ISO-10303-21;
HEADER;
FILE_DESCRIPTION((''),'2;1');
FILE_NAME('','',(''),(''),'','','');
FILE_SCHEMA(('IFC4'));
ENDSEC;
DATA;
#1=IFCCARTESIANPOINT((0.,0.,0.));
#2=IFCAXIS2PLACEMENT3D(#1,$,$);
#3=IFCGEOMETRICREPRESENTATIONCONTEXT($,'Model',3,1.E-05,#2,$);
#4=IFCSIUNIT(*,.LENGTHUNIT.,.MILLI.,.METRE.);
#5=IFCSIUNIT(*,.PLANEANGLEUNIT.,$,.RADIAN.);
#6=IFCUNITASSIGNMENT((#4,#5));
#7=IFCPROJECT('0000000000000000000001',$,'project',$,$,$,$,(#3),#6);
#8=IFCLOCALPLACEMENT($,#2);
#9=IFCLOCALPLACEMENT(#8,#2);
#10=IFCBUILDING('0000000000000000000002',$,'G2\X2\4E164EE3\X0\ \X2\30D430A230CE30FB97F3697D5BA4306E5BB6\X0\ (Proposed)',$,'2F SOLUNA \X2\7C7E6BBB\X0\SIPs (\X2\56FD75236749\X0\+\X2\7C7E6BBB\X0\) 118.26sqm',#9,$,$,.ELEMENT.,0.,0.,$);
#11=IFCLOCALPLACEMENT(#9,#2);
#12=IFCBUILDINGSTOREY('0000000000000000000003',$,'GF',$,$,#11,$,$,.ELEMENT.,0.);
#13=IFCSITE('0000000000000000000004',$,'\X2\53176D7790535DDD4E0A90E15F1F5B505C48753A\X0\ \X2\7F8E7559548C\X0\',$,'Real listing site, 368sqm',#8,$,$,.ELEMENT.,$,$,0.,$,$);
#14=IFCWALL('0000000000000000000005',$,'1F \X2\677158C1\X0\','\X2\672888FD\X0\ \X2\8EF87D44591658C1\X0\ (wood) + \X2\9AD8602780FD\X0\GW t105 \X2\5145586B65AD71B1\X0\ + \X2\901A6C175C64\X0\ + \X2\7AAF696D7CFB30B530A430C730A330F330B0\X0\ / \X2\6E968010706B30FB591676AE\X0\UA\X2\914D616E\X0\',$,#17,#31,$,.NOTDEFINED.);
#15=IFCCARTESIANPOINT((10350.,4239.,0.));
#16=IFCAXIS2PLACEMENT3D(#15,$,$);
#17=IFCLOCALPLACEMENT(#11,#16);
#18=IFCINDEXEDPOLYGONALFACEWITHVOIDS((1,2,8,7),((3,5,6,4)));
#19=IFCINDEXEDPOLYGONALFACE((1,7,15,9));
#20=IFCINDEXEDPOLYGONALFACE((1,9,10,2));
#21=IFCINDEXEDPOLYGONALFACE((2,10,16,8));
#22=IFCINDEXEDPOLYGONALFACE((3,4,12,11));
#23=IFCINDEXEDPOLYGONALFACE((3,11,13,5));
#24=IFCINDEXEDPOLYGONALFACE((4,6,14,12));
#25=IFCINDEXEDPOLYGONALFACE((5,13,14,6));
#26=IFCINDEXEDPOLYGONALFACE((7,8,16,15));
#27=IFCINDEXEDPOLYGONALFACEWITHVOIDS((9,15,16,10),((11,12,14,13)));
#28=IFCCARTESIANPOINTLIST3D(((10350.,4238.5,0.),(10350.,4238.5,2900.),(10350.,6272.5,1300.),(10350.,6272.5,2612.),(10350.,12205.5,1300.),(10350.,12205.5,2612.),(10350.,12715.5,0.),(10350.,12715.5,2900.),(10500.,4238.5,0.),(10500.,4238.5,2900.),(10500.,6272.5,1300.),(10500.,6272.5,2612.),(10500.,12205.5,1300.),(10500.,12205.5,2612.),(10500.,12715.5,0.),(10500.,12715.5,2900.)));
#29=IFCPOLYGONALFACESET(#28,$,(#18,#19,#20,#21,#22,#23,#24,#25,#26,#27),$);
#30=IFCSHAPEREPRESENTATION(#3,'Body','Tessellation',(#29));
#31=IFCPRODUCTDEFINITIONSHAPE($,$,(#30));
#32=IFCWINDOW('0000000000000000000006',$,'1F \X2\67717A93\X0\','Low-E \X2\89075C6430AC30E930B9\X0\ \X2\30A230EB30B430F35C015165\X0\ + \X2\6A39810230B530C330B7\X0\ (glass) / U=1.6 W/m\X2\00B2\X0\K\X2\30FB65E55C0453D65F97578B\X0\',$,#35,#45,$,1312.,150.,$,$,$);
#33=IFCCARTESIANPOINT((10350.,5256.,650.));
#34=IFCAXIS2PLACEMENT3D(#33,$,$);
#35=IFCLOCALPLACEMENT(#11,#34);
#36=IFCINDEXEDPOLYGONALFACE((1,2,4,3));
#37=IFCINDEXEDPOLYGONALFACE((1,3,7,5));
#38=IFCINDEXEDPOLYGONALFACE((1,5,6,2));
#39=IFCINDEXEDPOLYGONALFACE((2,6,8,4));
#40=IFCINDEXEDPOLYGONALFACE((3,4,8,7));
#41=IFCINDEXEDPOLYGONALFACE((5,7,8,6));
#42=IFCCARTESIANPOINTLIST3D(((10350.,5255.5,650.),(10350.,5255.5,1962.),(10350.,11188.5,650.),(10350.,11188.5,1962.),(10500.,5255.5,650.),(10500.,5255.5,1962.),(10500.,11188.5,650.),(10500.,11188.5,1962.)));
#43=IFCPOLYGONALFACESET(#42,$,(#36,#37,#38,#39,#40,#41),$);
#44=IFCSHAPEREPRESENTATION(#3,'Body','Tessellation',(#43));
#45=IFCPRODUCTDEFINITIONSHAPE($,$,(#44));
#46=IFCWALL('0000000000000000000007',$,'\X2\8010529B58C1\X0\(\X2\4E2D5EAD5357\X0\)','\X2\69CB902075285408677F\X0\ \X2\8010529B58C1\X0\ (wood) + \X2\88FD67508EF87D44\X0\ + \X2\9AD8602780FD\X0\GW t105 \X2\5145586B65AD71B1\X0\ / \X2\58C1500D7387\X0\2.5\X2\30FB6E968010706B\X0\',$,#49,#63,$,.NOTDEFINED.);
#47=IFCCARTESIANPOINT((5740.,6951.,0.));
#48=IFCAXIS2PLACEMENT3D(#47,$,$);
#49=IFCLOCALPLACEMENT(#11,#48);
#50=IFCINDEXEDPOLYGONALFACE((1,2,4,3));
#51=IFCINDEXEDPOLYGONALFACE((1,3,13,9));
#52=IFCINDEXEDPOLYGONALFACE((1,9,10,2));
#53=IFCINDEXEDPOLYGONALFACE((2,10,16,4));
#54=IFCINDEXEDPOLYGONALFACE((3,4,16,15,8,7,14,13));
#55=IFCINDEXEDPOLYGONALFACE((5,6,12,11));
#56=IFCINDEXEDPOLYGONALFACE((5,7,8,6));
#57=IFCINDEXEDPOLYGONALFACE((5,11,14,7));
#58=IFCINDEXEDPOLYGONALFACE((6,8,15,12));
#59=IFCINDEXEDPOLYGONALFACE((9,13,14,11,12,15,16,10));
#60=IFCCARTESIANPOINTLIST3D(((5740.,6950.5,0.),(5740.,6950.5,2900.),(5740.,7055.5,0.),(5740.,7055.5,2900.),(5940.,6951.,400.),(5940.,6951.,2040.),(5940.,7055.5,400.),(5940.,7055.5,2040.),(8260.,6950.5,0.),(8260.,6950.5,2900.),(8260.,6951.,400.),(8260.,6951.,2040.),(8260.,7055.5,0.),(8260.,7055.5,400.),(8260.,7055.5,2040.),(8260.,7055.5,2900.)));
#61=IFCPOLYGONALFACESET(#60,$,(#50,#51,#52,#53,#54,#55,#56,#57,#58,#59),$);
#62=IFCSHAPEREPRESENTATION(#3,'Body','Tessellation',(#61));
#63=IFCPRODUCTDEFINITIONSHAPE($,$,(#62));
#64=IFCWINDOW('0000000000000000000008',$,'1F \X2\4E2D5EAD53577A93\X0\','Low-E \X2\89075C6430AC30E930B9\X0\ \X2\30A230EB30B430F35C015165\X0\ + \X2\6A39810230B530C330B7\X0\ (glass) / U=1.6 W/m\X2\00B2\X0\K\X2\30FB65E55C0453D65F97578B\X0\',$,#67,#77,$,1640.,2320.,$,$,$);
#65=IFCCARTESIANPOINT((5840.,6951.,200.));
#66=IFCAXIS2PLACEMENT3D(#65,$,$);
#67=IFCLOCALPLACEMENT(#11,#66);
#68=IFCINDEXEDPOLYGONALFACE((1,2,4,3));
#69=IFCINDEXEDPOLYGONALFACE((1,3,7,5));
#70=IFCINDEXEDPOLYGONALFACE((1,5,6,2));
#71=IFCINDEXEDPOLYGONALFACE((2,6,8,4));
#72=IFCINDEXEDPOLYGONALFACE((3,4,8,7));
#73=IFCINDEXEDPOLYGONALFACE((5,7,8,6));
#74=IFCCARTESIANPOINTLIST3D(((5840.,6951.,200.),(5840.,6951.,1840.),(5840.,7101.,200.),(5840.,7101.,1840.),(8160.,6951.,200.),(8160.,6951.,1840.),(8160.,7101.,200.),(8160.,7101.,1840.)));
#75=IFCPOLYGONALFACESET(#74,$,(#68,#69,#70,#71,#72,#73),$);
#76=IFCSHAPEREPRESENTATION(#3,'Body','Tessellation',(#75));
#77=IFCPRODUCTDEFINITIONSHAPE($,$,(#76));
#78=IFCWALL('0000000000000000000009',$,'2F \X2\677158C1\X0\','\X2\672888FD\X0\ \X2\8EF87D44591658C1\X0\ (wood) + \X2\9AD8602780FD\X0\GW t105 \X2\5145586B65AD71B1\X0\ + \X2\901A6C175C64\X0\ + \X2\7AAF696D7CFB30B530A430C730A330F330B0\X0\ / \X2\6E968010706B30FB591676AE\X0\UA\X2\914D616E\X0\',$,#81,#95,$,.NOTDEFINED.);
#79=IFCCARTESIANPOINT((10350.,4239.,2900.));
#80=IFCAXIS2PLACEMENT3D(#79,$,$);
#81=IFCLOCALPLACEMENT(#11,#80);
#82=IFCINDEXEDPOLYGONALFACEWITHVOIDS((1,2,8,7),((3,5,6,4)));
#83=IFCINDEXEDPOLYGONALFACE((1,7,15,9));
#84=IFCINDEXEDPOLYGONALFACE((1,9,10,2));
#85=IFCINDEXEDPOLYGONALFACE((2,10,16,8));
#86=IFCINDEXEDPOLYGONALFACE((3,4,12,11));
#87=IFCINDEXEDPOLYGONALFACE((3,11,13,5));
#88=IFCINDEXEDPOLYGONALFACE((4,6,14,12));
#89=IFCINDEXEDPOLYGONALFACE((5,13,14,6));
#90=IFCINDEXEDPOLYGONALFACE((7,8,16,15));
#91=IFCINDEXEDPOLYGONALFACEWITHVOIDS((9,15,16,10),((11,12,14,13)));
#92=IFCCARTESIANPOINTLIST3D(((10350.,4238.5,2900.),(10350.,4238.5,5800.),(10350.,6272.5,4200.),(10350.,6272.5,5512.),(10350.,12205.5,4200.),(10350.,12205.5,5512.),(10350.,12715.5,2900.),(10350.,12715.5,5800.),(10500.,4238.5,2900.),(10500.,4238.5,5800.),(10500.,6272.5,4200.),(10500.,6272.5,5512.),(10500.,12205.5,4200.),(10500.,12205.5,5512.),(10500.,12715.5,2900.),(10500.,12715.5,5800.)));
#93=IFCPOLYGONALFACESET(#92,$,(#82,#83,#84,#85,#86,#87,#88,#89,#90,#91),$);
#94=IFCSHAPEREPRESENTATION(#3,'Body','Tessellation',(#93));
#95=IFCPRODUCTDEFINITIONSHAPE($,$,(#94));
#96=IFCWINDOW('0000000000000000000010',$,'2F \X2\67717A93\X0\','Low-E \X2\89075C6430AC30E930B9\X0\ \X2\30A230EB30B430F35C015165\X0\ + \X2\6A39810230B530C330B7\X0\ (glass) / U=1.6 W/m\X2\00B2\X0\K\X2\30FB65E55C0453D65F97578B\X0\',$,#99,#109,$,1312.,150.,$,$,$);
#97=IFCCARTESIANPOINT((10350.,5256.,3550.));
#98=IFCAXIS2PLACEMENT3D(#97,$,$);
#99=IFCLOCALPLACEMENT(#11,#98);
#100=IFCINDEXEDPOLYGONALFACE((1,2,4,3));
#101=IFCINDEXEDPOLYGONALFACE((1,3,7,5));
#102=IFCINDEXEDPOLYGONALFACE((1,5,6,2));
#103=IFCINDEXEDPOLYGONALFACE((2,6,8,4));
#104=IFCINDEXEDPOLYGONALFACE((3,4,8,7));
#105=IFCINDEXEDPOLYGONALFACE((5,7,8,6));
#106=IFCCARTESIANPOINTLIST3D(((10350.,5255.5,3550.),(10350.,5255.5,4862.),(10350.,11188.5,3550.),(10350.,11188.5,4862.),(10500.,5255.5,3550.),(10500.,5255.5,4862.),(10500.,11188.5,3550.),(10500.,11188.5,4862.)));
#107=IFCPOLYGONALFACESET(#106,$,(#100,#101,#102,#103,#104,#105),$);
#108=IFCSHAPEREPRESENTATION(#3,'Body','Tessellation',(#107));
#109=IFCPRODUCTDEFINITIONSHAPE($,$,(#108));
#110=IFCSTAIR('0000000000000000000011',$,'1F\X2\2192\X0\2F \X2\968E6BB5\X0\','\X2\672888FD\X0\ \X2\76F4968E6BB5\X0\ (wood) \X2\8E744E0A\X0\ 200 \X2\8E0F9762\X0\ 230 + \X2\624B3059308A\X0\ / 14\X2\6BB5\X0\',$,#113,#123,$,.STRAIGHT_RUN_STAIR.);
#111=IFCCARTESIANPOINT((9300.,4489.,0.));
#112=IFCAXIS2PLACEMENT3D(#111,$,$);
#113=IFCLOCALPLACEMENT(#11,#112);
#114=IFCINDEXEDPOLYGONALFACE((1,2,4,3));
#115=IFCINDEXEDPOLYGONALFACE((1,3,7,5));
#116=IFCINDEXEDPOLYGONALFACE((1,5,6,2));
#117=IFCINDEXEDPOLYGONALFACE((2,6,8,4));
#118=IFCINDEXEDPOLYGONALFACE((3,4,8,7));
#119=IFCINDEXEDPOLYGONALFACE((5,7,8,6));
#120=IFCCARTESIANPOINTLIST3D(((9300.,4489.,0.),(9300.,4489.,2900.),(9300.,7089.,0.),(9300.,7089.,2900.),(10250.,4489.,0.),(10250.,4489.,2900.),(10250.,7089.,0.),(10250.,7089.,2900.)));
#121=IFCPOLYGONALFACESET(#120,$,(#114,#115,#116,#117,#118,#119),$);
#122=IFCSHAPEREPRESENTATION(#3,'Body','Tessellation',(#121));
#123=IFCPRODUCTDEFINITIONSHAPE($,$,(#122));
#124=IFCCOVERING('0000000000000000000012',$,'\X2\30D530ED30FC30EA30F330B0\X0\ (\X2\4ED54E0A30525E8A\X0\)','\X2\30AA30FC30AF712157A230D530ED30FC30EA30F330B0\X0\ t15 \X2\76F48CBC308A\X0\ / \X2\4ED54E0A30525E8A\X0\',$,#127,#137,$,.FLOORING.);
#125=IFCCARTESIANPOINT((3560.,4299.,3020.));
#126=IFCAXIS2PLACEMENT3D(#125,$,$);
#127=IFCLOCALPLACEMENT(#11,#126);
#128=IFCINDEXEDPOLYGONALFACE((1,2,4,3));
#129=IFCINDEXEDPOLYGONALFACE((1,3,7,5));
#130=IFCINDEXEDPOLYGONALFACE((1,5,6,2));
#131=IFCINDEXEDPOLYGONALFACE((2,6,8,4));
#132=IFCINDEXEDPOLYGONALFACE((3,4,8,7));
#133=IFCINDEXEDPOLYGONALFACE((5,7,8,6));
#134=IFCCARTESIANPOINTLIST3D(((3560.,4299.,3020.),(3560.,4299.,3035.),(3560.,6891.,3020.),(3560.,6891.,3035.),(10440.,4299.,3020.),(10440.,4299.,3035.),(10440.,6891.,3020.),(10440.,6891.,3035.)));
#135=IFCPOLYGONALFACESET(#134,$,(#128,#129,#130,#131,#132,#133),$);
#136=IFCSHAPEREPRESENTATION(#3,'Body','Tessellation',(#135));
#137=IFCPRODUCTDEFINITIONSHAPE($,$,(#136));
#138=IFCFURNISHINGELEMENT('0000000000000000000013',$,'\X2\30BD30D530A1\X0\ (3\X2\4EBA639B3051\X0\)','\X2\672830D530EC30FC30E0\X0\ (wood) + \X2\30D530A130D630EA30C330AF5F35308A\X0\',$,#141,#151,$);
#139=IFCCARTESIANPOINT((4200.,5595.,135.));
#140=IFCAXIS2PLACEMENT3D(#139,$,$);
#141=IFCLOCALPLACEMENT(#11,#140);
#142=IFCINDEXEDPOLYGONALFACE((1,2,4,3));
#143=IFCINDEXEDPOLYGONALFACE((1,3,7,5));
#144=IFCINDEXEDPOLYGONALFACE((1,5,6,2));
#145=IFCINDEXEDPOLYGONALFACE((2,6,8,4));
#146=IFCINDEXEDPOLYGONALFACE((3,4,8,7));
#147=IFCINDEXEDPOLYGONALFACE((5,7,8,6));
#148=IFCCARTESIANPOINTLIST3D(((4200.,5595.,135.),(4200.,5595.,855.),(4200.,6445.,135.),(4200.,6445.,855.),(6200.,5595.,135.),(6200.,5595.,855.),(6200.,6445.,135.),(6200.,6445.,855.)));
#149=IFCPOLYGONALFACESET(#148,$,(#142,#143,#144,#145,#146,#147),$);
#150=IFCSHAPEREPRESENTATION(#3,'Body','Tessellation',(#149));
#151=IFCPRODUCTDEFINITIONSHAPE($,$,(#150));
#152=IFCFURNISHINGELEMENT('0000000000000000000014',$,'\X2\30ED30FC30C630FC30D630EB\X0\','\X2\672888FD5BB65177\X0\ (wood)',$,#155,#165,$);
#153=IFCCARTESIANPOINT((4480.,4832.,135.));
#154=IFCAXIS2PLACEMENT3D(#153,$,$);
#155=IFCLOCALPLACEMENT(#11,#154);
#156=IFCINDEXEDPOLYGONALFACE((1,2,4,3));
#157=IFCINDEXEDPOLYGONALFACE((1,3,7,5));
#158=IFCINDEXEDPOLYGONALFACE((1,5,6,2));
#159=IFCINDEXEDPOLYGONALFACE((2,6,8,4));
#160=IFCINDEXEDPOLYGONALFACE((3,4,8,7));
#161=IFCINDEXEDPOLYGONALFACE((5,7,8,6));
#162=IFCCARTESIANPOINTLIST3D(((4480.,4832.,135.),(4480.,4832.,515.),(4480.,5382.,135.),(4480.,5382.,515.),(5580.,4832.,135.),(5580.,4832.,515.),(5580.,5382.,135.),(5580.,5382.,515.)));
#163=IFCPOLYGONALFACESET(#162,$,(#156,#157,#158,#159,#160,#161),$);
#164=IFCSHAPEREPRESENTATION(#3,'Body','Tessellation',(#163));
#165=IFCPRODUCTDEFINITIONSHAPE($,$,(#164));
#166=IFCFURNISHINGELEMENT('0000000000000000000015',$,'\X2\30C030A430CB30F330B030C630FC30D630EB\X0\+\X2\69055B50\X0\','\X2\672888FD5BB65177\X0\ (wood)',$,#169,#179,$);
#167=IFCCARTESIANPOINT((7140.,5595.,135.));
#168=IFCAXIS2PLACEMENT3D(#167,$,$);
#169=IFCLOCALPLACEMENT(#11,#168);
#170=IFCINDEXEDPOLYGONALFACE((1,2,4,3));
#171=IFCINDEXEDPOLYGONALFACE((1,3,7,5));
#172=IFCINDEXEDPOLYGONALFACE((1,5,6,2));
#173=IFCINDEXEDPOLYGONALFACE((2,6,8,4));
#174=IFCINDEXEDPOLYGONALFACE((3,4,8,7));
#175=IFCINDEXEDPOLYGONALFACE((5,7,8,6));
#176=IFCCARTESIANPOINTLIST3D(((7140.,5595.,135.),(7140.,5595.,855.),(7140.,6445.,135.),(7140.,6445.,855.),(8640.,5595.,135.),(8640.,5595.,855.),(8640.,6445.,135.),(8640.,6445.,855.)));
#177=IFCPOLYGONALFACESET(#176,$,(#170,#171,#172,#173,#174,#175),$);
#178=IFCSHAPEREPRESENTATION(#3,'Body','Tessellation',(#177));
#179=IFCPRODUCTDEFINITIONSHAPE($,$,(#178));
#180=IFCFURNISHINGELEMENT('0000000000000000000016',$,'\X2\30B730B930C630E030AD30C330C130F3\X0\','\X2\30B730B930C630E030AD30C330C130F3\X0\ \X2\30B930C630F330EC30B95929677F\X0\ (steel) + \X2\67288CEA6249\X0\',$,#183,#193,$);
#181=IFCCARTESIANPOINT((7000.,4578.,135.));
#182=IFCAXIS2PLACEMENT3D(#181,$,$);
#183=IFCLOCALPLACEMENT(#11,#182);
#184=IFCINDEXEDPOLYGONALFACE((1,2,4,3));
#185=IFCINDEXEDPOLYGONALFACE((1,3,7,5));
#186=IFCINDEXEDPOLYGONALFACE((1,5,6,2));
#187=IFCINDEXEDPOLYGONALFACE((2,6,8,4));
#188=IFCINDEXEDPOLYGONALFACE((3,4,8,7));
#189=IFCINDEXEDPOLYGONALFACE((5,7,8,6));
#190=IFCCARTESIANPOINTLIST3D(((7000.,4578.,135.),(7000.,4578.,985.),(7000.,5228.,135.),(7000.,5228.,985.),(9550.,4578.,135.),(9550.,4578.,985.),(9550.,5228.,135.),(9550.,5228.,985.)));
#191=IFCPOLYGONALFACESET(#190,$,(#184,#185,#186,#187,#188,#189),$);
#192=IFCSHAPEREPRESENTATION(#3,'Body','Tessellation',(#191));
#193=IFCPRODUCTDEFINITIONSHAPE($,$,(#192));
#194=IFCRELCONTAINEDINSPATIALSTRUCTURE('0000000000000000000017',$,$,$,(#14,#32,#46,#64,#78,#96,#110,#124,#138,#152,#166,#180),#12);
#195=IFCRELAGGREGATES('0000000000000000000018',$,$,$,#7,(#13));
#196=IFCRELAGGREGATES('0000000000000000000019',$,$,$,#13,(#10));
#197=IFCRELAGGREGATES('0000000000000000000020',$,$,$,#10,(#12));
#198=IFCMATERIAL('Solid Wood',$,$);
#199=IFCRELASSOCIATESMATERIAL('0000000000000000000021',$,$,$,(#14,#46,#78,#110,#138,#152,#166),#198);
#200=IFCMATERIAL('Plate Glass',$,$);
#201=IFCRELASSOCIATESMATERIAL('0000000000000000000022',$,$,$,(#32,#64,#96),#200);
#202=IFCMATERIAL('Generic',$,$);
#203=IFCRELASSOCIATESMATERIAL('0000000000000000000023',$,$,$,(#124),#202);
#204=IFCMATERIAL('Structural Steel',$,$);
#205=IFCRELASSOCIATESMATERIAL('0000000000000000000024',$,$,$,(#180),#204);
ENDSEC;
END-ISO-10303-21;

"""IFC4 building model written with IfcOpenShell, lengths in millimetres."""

from ifc_helpers import new_model, si_unit, frame, frame_2d, origin, place, context, project, spatial, rectangle, extrude, material, element, fill, save


model = new_model("IFC4")

# Units and contexts
model_context = context("Model", 3, precision=1e-05, world=origin())
ifc_project = project(units=[si_unit("LENGTHUNIT", "METRE", prefix="MILLI"), si_unit("PLANEANGLEUNIT", "RADIAN")], contexts=[model_context])

# Site, building, storey
site_placement = place(None, origin())
site = spatial("IfcSite", under=ifc_project, at=site_placement, Name="北海道川上郡弟子屈町 美留和", ObjectType="Real listing site, 368sqm", CompositionType="ELEMENT", RefElevation=0.0)
building_placement = place(site_placement, origin())
building = spatial("IfcBuilding", under=site, at=building_placement, Name="G2世代 ピアノ・音楽室の家 (Proposed)", ObjectType="2F SOLUNA 籾殻SIPs (国産杉+籾殻) 118.26sqm", CompositionType="ELEMENT", ElevationOfRefHeight=0.0, ElevationOfTerrain=0.0)
storey_placement = place(building_placement, origin())
storey = spatial("IfcBuildingStorey", under=building, at=storey_placement, Name="GF", CompositionType="ELEMENT", Elevation=0.0)

# Shared definitions
ifc_material_1 = material(Name="Solid Wood")

# Walls, openings, windows
wall_1_placement = place(storey_placement, frame((10350.0, 4239.0, 0.0)))
wall_1 = element("IfcWall", 1, at=wall_1_placement, inside=storey, material=ifc_material_1, Name="1F 東壁", Description="木製 軸組外壁 (wood) + 高性能GW t105 充填断熱 + 通気層 + 窯業系サイディング / 準耐火・外皮UA配慮", PredefinedType="NOTDEFINED", context=model_context, shape_type="SweptSolid", body=[
    extrude(rectangle(XDim=150.0, YDim=8477.0, at=frame_2d((75.0, 4238.0))), frame((10350.0, 4239.0, 0.0)), (0.0, 0.0, 1.0), 2900.0),
])
opening_1_placement = place(storey_placement, frame((10350.0, 5256.0, 650.0)))
opening_1 = element("IfcOpeningElement", 2, at=opening_1_placement, cuts=wall_1, PredefinedType="NOTDEFINED", context=model_context, shape_type="SweptSolid", body=[
    extrude(rectangle(XDim=150.0, YDim=5933.0, at=frame_2d((75.0, 2966.0))), frame((10350.0, 5256.0, 650.0)), (0.0, 0.0, 1.0), 1312.0),
])
ifc_material_2 = material(Name="Plate Glass")
window_1_placement = place(storey_placement, frame((10350.0, 5256.0, 650.0)))
window_1 = element("IfcWindow", 3, at=window_1_placement, inside=storey, material=ifc_material_2, Name="1F 東窓", Description="Low-E 複層ガラス アルゴン封入 + 樹脂サッシ (glass) / U=1.6 W/m²K・日射取得型", OverallHeight=1312.0, OverallWidth=150.0, context=model_context, shape_type="SweptSolid", body=[
    extrude(rectangle(XDim=150.0, YDim=5933.0, at=frame_2d((75.0, 2966.0))), frame((10350.0, 5256.0, 650.0)), (0.0, 0.0, 1.0), 1312.0),
])
fill(opening_1, window_1)
wall_2_placement = place(storey_placement, frame((5740.0, 6951.0, 0.0)))
wall_2 = element("IfcWall", 4, at=wall_2_placement, inside=storey, material=ifc_material_1, Name="耐力壁(中庭南)", Description="構造用合板 耐力壁 (wood) + 製材軸組 + 高性能GW t105 充填断熱 / 壁倍率2.5・準耐火", PredefinedType="NOTDEFINED", context=model_context, shape_type="SweptSolid", body=[
    extrude(rectangle(XDim=2520.0, YDim=105.0, at=frame_2d((1260.0, 52.0))), frame((5740.0, 6951.0, 0.0)), (0.0, 0.0, 1.0), 2900.0),
])
opening_2_placement = place(storey_placement, frame((5840.0, 6951.0, 200.0)))
opening_2 = element("IfcOpeningElement", 5, at=opening_2_placement, cuts=wall_2, PredefinedType="NOTDEFINED", context=model_context, shape_type="SweptSolid", body=[
    extrude(rectangle(XDim=2320.0, YDim=150.0, at=frame_2d((1160.0, 75.0))), frame((5840.0, 6951.0, 200.0)), (0.0, 0.0, 1.0), 1640.0),
])
window_2_placement = place(storey_placement, frame((5840.0, 6951.0, 200.0)))
window_2 = element("IfcWindow", 6, at=window_2_placement, inside=storey, material=ifc_material_2, Name="1F 中庭南窓", Description="Low-E 複層ガラス アルゴン封入 + 樹脂サッシ (glass) / U=1.6 W/m²K・日射取得型", OverallHeight=1640.0, OverallWidth=2320.0, context=model_context, shape_type="SweptSolid", body=[
    extrude(rectangle(XDim=2320.0, YDim=150.0, at=frame_2d((1160.0, 75.0))), frame((5840.0, 6951.0, 200.0)), (0.0, 0.0, 1.0), 1640.0),
])
fill(opening_2, window_2)

# Wall, opening, window
wall_3_placement = place(storey_placement, frame((10350.0, 4239.0, 2900.0)))
wall_3 = element("IfcWall", 7, at=wall_3_placement, inside=storey, material=ifc_material_1, Name="2F 東壁", Description="木製 軸組外壁 (wood) + 高性能GW t105 充填断熱 + 通気層 + 窯業系サイディング / 準耐火・外皮UA配慮", PredefinedType="NOTDEFINED", context=model_context, shape_type="SweptSolid", body=[
    extrude(rectangle(XDim=150.0, YDim=8477.0, at=frame_2d((75.0, 4238.0))), frame((10350.0, 4239.0, 2900.0)), (0.0, 0.0, 1.0), 2900.0),
])
opening_3_placement = place(storey_placement, frame((10350.0, 5256.0, 3550.0)))
opening_3 = element("IfcOpeningElement", 8, at=opening_3_placement, cuts=wall_3, PredefinedType="NOTDEFINED", context=model_context, shape_type="SweptSolid", body=[
    extrude(rectangle(XDim=150.0, YDim=5933.0, at=frame_2d((75.0, 2966.0))), frame((10350.0, 5256.0, 3550.0)), (0.0, 0.0, 1.0), 1312.0),
])
window_3_placement = place(storey_placement, frame((10350.0, 5256.0, 3550.0)))
window_3 = element("IfcWindow", 9, at=window_3_placement, inside=storey, material=ifc_material_2, Name="2F 東窓", Description="Low-E 複層ガラス アルゴン封入 + 樹脂サッシ (glass) / U=1.6 W/m²K・日射取得型", OverallHeight=1312.0, OverallWidth=150.0, context=model_context, shape_type="SweptSolid", body=[
    extrude(rectangle(XDim=150.0, YDim=5933.0, at=frame_2d((75.0, 2966.0))), frame((10350.0, 5256.0, 3550.0)), (0.0, 0.0, 1.0), 1312.0),
])
fill(opening_3, window_3)

# Stair
stair_placement = place(storey_placement, frame((9300.0, 4489.0, 0.0)))
element("IfcStair", 10, at=stair_placement, inside=storey, material=ifc_material_1, Name="1F→2F 階段", Description="木製 直階段 (wood) 蹴上 200 踏面 230 + 手すり / 14段", PredefinedType="STRAIGHT_RUN_STAIR", context=model_context, shape_type="SweptSolid", body=[
    extrude(rectangle(XDim=950.0, YDim=2600.0, at=frame_2d((475.0, 1300.0))), frame((9300.0, 4489.0, 0.0)), (0.0, 0.0, 1.0), 2900.0),
])

# Covering
ifc_material_3 = material(Name="Generic")
covering_placement = place(storey_placement, frame((3560.0, 4299.0, 3020.0)))
element("IfcCovering", 11, at=covering_placement, inside=storey, material=ifc_material_3, Name="フローリング (仕上げ床)", Description="オーク無垢フローリング t15 直貼り / 仕上げ床", PredefinedType="FLOORING", context=model_context, shape_type="SweptSolid", body=[
    extrude(rectangle(XDim=6880.0, YDim=2592.0, at=frame_2d((3440.0, 1296.0))), frame((3560.0, 4299.0, 3020.0)), (0.0, 0.0, 1.0), 15.0),
])

# Furnishing elements
furnishing_1_placement = place(storey_placement, frame((4200.0, 5595.0, 135.0)))
element("IfcFurnishingElement", 12, at=furnishing_1_placement, inside=storey, material=ifc_material_1, Name="ソファ (3人掛け)", Description="木フレーム (wood) + ファブリック張り", context=model_context, shape_type="SweptSolid", body=[
    extrude(rectangle(XDim=2000.0, YDim=850.0, at=frame_2d((1000.0, 425.0))), frame((4200.0, 5595.0, 135.0)), (0.0, 0.0, 1.0), 720.0),
])
furnishing_2_placement = place(storey_placement, frame((4480.0, 4832.0, 135.0)))
element("IfcFurnishingElement", 13, at=furnishing_2_placement, inside=storey, material=ifc_material_1, Name="ローテーブル", Description="木製家具 (wood)", context=model_context, shape_type="SweptSolid", body=[
    extrude(rectangle(XDim=1100.0, YDim=550.0, at=frame_2d((550.0, 275.0))), frame((4480.0, 4832.0, 135.0)), (0.0, 0.0, 1.0), 380.0),
])
furnishing_3_placement = place(storey_placement, frame((7140.0, 5595.0, 135.0)))
element("IfcFurnishingElement", 14, at=furnishing_3_placement, inside=storey, material=ifc_material_1, Name="ダイニングテーブル+椅子", Description="木製家具 (wood)", context=model_context, shape_type="SweptSolid", body=[
    extrude(rectangle(XDim=1500.0, YDim=850.0, at=frame_2d((750.0, 425.0))), frame((7140.0, 5595.0, 135.0)), (0.0, 0.0, 1.0), 720.0),
])
ifc_material_4 = material(Name="Structural Steel")
furnishing_4_placement = place(storey_placement, frame((7000.0, 4578.0, 135.0)))
element("IfcFurnishingElement", 15, at=furnishing_4_placement, inside=storey, material=ifc_material_4, Name="システムキッチン", Description="システムキッチン ステンレス天板 (steel) + 木質扉", context=model_context, shape_type="SweptSolid", body=[
    extrude(rectangle(XDim=2550.0, YDim=650.0, at=frame_2d((1275.0, 325.0))), frame((7000.0, 4578.0, 135.0)), (0.0, 0.0, 1.0), 850.0),
])

save(model, "model.ifc")
